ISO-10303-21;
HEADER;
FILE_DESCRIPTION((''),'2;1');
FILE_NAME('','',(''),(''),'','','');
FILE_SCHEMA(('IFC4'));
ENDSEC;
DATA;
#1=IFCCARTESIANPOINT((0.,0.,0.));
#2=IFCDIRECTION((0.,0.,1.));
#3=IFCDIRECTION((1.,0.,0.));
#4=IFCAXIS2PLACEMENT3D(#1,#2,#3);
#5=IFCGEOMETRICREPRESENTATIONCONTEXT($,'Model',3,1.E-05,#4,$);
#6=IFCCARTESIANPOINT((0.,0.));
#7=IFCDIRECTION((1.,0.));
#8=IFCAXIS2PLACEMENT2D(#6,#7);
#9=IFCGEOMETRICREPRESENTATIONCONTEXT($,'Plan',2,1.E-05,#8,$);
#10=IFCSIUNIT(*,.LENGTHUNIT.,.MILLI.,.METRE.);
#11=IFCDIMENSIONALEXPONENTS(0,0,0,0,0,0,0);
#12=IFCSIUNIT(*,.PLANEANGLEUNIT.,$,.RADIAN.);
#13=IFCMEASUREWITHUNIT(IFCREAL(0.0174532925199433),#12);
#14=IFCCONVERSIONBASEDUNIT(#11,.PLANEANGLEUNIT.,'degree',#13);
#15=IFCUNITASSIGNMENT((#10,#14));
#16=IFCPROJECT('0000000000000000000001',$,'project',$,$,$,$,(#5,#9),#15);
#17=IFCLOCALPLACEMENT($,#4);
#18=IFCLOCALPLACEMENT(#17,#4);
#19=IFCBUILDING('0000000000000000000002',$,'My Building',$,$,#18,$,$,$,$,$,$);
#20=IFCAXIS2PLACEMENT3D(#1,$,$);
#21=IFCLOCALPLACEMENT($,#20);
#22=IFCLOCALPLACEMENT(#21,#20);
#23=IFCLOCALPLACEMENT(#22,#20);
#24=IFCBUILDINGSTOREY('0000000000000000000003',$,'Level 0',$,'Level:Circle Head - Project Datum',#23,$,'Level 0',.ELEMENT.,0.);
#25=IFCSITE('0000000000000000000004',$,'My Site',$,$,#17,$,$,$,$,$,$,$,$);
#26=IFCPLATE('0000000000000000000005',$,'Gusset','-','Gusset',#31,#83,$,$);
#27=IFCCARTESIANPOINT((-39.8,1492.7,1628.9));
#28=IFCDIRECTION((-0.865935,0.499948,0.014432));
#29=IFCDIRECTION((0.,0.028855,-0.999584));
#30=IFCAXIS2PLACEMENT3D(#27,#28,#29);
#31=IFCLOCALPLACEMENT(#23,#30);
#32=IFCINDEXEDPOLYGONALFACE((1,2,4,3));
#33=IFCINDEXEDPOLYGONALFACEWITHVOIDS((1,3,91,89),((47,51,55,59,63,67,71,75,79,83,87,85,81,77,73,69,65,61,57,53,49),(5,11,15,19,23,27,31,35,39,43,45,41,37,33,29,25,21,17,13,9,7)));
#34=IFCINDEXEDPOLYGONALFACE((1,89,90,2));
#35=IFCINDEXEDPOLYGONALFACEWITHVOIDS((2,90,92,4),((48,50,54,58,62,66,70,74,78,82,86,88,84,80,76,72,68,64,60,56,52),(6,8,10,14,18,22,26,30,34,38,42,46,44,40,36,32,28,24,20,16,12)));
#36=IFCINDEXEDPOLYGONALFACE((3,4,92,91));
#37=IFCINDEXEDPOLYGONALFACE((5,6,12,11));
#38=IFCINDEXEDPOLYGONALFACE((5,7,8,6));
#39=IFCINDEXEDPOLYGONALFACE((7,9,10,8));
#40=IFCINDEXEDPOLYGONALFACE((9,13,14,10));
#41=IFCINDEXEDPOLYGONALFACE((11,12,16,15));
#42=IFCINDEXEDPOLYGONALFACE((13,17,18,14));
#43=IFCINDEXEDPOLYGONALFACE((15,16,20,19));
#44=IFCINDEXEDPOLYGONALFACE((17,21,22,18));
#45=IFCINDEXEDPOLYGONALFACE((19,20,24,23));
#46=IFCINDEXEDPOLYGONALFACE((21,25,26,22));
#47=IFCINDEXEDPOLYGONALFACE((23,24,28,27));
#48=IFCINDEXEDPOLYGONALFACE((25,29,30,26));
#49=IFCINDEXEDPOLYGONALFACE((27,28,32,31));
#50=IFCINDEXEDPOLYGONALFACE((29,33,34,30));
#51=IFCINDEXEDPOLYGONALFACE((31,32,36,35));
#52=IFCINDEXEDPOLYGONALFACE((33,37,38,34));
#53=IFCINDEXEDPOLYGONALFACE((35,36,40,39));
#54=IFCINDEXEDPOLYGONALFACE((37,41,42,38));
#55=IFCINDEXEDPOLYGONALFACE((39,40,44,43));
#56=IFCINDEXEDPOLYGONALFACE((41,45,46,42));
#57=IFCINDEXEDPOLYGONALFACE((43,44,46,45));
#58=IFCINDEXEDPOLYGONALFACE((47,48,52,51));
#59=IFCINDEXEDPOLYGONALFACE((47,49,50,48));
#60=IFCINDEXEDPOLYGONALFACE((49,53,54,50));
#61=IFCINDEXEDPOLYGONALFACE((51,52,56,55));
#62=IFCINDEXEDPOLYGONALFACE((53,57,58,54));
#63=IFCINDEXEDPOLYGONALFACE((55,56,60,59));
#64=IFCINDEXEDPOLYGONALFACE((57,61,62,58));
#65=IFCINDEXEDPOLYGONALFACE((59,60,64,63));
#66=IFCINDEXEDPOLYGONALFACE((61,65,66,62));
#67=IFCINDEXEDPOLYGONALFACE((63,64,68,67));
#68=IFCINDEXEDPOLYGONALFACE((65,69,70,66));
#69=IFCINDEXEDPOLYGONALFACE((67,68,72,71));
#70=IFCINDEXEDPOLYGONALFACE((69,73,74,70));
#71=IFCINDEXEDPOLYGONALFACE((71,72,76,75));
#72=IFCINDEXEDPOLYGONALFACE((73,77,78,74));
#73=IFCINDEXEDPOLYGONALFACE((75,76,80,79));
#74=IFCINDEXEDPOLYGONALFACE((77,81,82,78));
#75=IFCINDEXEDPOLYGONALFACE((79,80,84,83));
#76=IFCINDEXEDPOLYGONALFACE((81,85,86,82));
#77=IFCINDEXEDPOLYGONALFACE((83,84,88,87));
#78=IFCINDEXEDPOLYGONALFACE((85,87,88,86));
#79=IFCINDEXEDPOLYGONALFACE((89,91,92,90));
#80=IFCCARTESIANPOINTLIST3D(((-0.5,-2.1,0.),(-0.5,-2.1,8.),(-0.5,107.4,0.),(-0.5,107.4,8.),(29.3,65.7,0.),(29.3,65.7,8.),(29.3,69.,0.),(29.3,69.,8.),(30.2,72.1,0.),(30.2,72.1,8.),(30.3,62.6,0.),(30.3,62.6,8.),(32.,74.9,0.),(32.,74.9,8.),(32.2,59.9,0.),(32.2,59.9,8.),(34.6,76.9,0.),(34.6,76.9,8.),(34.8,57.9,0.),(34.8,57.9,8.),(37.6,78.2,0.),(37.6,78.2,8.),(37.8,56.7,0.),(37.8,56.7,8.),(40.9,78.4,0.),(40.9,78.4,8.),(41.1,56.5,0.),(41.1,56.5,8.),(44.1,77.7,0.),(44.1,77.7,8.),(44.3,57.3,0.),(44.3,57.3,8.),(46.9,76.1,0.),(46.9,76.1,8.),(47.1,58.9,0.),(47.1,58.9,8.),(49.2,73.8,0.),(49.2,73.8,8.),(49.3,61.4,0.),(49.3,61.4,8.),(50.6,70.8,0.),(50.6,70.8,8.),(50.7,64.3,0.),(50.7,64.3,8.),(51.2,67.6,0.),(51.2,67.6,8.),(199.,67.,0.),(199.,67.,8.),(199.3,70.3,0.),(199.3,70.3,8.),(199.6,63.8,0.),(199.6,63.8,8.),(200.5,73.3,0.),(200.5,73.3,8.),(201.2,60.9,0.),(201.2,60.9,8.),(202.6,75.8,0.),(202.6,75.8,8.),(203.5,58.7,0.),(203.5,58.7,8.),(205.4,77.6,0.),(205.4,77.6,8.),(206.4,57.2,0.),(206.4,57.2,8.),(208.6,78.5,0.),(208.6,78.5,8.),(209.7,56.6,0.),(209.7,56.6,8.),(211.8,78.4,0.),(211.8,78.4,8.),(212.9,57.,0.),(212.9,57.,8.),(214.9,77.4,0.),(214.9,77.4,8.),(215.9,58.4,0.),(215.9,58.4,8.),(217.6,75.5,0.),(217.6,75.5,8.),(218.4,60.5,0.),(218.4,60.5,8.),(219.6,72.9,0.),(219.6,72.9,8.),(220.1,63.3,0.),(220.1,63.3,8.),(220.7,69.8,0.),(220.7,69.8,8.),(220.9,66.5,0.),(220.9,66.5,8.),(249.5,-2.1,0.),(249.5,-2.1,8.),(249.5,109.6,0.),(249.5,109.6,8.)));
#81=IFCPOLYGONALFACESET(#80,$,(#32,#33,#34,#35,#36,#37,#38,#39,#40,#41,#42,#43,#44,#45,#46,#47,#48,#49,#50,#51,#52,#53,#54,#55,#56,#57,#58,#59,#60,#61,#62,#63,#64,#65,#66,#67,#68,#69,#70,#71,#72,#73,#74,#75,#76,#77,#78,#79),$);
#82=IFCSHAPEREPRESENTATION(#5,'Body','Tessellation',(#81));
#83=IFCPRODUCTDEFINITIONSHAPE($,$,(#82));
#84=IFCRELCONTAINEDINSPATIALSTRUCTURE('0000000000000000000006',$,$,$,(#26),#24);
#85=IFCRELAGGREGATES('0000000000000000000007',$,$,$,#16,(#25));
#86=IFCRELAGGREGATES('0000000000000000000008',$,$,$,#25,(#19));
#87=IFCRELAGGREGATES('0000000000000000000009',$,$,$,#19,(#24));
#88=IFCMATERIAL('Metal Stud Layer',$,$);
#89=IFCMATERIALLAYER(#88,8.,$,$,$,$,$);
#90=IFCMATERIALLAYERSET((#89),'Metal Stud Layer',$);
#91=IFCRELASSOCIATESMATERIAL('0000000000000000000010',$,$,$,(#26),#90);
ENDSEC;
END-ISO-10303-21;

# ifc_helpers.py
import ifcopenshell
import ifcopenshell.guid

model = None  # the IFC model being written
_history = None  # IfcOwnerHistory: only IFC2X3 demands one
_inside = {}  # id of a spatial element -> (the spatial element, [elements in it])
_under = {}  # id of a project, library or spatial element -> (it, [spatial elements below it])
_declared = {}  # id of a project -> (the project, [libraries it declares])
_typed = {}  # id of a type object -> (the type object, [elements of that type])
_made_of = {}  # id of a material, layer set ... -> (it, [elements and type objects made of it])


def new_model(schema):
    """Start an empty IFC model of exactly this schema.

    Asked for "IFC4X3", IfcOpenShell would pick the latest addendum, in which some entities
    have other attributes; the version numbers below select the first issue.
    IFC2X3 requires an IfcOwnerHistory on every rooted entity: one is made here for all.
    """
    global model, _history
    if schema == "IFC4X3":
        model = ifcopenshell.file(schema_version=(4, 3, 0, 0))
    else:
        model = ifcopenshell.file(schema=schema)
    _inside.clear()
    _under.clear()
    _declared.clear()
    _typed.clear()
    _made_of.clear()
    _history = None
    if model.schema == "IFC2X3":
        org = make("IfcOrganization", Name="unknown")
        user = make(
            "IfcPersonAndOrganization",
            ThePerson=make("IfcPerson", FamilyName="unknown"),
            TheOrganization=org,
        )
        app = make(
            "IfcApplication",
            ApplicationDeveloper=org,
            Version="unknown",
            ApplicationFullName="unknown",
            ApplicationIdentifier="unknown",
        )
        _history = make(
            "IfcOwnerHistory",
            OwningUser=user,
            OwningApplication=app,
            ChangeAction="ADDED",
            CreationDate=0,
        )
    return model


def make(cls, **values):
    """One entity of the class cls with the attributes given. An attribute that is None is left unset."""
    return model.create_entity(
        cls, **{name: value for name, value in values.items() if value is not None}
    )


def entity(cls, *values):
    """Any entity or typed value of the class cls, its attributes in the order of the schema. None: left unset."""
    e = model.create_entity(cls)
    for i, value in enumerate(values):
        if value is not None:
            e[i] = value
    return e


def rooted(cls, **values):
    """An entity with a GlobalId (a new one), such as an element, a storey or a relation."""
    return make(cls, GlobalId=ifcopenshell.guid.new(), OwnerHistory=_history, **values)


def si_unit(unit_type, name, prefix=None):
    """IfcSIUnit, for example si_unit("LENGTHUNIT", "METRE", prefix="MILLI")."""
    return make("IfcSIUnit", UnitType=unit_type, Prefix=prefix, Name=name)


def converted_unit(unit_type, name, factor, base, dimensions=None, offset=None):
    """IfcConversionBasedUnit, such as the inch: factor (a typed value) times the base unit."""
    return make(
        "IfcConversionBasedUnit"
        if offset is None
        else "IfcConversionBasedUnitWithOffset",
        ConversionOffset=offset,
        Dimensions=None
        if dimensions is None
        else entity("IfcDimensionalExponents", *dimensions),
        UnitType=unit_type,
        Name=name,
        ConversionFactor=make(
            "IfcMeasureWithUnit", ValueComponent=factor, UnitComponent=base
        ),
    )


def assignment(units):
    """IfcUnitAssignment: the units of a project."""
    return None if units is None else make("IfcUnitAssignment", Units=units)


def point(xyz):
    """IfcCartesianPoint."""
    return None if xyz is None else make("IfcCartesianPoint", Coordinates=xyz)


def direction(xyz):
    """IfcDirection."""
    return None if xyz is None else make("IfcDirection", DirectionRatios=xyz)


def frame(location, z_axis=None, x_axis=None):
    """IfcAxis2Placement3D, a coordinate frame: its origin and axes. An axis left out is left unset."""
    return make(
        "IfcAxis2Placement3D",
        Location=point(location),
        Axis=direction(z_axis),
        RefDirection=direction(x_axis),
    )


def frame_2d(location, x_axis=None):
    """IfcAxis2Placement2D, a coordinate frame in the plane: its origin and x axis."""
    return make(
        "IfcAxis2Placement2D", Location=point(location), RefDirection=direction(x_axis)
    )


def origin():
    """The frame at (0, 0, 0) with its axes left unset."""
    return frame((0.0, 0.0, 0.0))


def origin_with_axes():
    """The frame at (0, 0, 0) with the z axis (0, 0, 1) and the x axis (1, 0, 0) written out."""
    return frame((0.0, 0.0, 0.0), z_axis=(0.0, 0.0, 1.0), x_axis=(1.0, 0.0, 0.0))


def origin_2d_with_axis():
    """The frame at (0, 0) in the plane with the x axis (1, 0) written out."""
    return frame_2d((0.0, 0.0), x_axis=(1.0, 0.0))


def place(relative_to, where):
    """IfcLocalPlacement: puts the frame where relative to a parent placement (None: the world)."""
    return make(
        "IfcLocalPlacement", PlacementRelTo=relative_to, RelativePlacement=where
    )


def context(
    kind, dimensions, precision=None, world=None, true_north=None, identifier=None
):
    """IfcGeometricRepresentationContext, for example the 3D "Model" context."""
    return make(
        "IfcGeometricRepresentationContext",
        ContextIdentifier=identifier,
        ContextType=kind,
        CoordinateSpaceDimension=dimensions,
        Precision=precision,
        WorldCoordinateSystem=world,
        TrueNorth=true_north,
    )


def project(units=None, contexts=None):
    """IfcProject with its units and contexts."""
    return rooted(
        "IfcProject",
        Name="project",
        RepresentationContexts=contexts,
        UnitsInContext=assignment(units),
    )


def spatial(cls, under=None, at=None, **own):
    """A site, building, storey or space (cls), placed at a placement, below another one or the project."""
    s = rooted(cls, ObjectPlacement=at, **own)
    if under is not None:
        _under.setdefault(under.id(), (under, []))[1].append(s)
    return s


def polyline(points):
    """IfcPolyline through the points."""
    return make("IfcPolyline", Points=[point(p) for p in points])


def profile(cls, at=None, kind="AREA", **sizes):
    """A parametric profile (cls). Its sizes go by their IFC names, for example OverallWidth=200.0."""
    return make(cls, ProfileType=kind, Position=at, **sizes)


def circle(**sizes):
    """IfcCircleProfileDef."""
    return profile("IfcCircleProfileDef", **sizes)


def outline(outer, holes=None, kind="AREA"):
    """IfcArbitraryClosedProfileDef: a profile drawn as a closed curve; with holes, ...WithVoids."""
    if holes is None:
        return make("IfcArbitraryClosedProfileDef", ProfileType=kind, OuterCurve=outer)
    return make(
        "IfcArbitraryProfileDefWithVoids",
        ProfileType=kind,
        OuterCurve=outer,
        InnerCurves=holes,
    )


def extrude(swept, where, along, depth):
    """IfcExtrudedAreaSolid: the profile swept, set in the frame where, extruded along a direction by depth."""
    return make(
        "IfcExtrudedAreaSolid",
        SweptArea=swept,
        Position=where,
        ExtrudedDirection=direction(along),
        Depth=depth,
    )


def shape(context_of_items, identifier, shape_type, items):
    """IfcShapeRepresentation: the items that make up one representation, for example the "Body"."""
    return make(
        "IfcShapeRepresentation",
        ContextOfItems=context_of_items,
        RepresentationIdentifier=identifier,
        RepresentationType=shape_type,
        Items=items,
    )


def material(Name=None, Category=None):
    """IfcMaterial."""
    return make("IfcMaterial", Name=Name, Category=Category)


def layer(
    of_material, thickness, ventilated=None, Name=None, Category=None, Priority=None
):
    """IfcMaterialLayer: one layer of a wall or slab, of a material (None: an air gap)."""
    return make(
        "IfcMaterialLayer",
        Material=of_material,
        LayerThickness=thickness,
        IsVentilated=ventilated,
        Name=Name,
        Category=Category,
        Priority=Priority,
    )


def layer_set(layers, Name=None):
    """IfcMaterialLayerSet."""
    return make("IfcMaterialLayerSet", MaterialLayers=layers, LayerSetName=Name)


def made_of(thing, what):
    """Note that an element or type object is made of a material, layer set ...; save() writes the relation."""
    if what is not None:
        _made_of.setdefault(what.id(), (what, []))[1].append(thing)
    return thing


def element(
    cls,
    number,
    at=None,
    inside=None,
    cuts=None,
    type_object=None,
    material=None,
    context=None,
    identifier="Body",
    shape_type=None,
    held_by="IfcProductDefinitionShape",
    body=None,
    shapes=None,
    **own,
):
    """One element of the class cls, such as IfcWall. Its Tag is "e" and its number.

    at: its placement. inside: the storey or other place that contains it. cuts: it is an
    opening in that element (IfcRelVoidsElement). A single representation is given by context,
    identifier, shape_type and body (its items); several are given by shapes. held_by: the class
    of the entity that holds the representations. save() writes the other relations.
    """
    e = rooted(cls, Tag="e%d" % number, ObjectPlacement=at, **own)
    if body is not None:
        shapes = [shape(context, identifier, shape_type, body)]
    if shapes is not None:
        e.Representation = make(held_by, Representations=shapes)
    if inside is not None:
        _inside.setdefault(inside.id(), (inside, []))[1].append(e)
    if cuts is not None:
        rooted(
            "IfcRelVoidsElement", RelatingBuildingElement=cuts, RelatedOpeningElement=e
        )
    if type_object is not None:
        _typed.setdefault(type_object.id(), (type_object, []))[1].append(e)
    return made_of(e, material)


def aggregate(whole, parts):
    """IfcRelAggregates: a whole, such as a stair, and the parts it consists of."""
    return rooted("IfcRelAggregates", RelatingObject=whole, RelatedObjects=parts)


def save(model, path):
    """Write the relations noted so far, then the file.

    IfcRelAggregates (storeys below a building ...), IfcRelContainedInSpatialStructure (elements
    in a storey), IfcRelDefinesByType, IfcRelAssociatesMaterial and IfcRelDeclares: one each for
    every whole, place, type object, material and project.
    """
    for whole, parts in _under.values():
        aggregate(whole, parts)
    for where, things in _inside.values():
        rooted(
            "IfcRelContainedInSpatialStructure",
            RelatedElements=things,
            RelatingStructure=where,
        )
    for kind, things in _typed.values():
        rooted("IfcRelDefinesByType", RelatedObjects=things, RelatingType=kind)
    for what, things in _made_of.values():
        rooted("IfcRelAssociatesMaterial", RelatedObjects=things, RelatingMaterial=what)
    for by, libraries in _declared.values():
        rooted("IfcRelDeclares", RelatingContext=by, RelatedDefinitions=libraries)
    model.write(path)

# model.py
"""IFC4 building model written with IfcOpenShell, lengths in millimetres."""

from ifc_helpers import new_model, entity, si_unit, converted_unit, frame, origin, origin_with_axes, origin_2d_with_axis, place, context, project, spatial, polyline, circle, outline, extrude, material, layer, layer_set, element, save


model = new_model("IFC4")

# Units and contexts
model_context = context("Model", 3, precision=1e-05, world=origin_with_axes())
plan_context = context("Plan", 2, precision=1e-05, world=origin_2d_with_axis())
ifc_project = project(units=[si_unit("LENGTHUNIT", "METRE", prefix="MILLI"), converted_unit("PLANEANGLEUNIT", "degree", entity("IfcReal", 0.0174532925199433), si_unit("PLANEANGLEUNIT", "RADIAN"), dimensions=[0, 0, 0, 0, 0, 0, 0])], contexts=[model_context, plan_context])

# Site, building, storey
site_placement = place(None, origin_with_axes())
site = spatial("IfcSite", under=ifc_project, at=site_placement, Name="My Site")
building_placement = place(site_placement, origin_with_axes())
building = spatial("IfcBuilding", under=site, at=building_placement, Name="My Building")
placement_1 = place(None, origin())
placement_2 = place(placement_1, origin())
storey_placement = place(placement_2, origin())
storey = spatial("IfcBuildingStorey", under=building, at=storey_placement, Name="Level 0", ObjectType="Level:Circle Head - Project Datum", LongName="Level 0", CompositionType="ELEMENT", Elevation=0.0)

# Plate, openings
ifc_material = material(Name="Metal Stud Layer")
ifc_layer_1 = layer(ifc_material, 8.0)
ifc_layer_set_1 = layer_set([ifc_layer_1], Name="Metal Stud Layer")
plate_1_placement = place(storey_placement, frame((-39.8, 1492.7, 1628.9), z_axis=(-0.865935, 0.499948, 0.014432), x_axis=(0.0, 0.028855, -0.999584)))
plate_1 = element("IfcPlate", 1, at=plate_1_placement, inside=storey, material=ifc_layer_set_1, Name="Gusset", Description="-", ObjectType="Gusset", context=model_context, shape_type="SweptSolid", body=[
    extrude(outline(polyline([(-0.5, -2.1), (249.5, -2.1), (249.5, 109.6), (-0.5, 107.4), (-0.5, -2.1)])), origin_with_axes(), (0.0, 0.0, 1.0), 8.0),
])
opening_1_placement = place(plate_1_placement, frame((40.2, 67.5, 8.5), z_axis=(0.0, 0.0, -1.0), x_axis=(-0.509076, 0.860722, 0.0)))
element("IfcOpeningElement", 2, at=opening_1_placement, cuts=plate_1, ObjectType="Opening", context=model_context, shape_type="SweptSolid", body=[
    extrude(circle(Radius=11.0, at=origin_2d_with_axis()), origin(), (0.0, 0.0, 1.0), 9.0),
])
opening_2_placement = place(plate_1_placement, frame((209.9, 67.6, 8.5), z_axis=(0.0, 0.0, -1.0), x_axis=(0.455098, 0.890441, 0.0)))
element("IfcOpeningElement", 3, at=opening_2_placement, cuts=plate_1, ObjectType="Opening", context=model_context, shape_type="SweptSolid", body=[
    extrude(circle(Radius=11.0, at=origin_2d_with_axis()), origin(), (0.0, 0.0, 1.0), 9.0),
])

save(model, "model.ifc")
